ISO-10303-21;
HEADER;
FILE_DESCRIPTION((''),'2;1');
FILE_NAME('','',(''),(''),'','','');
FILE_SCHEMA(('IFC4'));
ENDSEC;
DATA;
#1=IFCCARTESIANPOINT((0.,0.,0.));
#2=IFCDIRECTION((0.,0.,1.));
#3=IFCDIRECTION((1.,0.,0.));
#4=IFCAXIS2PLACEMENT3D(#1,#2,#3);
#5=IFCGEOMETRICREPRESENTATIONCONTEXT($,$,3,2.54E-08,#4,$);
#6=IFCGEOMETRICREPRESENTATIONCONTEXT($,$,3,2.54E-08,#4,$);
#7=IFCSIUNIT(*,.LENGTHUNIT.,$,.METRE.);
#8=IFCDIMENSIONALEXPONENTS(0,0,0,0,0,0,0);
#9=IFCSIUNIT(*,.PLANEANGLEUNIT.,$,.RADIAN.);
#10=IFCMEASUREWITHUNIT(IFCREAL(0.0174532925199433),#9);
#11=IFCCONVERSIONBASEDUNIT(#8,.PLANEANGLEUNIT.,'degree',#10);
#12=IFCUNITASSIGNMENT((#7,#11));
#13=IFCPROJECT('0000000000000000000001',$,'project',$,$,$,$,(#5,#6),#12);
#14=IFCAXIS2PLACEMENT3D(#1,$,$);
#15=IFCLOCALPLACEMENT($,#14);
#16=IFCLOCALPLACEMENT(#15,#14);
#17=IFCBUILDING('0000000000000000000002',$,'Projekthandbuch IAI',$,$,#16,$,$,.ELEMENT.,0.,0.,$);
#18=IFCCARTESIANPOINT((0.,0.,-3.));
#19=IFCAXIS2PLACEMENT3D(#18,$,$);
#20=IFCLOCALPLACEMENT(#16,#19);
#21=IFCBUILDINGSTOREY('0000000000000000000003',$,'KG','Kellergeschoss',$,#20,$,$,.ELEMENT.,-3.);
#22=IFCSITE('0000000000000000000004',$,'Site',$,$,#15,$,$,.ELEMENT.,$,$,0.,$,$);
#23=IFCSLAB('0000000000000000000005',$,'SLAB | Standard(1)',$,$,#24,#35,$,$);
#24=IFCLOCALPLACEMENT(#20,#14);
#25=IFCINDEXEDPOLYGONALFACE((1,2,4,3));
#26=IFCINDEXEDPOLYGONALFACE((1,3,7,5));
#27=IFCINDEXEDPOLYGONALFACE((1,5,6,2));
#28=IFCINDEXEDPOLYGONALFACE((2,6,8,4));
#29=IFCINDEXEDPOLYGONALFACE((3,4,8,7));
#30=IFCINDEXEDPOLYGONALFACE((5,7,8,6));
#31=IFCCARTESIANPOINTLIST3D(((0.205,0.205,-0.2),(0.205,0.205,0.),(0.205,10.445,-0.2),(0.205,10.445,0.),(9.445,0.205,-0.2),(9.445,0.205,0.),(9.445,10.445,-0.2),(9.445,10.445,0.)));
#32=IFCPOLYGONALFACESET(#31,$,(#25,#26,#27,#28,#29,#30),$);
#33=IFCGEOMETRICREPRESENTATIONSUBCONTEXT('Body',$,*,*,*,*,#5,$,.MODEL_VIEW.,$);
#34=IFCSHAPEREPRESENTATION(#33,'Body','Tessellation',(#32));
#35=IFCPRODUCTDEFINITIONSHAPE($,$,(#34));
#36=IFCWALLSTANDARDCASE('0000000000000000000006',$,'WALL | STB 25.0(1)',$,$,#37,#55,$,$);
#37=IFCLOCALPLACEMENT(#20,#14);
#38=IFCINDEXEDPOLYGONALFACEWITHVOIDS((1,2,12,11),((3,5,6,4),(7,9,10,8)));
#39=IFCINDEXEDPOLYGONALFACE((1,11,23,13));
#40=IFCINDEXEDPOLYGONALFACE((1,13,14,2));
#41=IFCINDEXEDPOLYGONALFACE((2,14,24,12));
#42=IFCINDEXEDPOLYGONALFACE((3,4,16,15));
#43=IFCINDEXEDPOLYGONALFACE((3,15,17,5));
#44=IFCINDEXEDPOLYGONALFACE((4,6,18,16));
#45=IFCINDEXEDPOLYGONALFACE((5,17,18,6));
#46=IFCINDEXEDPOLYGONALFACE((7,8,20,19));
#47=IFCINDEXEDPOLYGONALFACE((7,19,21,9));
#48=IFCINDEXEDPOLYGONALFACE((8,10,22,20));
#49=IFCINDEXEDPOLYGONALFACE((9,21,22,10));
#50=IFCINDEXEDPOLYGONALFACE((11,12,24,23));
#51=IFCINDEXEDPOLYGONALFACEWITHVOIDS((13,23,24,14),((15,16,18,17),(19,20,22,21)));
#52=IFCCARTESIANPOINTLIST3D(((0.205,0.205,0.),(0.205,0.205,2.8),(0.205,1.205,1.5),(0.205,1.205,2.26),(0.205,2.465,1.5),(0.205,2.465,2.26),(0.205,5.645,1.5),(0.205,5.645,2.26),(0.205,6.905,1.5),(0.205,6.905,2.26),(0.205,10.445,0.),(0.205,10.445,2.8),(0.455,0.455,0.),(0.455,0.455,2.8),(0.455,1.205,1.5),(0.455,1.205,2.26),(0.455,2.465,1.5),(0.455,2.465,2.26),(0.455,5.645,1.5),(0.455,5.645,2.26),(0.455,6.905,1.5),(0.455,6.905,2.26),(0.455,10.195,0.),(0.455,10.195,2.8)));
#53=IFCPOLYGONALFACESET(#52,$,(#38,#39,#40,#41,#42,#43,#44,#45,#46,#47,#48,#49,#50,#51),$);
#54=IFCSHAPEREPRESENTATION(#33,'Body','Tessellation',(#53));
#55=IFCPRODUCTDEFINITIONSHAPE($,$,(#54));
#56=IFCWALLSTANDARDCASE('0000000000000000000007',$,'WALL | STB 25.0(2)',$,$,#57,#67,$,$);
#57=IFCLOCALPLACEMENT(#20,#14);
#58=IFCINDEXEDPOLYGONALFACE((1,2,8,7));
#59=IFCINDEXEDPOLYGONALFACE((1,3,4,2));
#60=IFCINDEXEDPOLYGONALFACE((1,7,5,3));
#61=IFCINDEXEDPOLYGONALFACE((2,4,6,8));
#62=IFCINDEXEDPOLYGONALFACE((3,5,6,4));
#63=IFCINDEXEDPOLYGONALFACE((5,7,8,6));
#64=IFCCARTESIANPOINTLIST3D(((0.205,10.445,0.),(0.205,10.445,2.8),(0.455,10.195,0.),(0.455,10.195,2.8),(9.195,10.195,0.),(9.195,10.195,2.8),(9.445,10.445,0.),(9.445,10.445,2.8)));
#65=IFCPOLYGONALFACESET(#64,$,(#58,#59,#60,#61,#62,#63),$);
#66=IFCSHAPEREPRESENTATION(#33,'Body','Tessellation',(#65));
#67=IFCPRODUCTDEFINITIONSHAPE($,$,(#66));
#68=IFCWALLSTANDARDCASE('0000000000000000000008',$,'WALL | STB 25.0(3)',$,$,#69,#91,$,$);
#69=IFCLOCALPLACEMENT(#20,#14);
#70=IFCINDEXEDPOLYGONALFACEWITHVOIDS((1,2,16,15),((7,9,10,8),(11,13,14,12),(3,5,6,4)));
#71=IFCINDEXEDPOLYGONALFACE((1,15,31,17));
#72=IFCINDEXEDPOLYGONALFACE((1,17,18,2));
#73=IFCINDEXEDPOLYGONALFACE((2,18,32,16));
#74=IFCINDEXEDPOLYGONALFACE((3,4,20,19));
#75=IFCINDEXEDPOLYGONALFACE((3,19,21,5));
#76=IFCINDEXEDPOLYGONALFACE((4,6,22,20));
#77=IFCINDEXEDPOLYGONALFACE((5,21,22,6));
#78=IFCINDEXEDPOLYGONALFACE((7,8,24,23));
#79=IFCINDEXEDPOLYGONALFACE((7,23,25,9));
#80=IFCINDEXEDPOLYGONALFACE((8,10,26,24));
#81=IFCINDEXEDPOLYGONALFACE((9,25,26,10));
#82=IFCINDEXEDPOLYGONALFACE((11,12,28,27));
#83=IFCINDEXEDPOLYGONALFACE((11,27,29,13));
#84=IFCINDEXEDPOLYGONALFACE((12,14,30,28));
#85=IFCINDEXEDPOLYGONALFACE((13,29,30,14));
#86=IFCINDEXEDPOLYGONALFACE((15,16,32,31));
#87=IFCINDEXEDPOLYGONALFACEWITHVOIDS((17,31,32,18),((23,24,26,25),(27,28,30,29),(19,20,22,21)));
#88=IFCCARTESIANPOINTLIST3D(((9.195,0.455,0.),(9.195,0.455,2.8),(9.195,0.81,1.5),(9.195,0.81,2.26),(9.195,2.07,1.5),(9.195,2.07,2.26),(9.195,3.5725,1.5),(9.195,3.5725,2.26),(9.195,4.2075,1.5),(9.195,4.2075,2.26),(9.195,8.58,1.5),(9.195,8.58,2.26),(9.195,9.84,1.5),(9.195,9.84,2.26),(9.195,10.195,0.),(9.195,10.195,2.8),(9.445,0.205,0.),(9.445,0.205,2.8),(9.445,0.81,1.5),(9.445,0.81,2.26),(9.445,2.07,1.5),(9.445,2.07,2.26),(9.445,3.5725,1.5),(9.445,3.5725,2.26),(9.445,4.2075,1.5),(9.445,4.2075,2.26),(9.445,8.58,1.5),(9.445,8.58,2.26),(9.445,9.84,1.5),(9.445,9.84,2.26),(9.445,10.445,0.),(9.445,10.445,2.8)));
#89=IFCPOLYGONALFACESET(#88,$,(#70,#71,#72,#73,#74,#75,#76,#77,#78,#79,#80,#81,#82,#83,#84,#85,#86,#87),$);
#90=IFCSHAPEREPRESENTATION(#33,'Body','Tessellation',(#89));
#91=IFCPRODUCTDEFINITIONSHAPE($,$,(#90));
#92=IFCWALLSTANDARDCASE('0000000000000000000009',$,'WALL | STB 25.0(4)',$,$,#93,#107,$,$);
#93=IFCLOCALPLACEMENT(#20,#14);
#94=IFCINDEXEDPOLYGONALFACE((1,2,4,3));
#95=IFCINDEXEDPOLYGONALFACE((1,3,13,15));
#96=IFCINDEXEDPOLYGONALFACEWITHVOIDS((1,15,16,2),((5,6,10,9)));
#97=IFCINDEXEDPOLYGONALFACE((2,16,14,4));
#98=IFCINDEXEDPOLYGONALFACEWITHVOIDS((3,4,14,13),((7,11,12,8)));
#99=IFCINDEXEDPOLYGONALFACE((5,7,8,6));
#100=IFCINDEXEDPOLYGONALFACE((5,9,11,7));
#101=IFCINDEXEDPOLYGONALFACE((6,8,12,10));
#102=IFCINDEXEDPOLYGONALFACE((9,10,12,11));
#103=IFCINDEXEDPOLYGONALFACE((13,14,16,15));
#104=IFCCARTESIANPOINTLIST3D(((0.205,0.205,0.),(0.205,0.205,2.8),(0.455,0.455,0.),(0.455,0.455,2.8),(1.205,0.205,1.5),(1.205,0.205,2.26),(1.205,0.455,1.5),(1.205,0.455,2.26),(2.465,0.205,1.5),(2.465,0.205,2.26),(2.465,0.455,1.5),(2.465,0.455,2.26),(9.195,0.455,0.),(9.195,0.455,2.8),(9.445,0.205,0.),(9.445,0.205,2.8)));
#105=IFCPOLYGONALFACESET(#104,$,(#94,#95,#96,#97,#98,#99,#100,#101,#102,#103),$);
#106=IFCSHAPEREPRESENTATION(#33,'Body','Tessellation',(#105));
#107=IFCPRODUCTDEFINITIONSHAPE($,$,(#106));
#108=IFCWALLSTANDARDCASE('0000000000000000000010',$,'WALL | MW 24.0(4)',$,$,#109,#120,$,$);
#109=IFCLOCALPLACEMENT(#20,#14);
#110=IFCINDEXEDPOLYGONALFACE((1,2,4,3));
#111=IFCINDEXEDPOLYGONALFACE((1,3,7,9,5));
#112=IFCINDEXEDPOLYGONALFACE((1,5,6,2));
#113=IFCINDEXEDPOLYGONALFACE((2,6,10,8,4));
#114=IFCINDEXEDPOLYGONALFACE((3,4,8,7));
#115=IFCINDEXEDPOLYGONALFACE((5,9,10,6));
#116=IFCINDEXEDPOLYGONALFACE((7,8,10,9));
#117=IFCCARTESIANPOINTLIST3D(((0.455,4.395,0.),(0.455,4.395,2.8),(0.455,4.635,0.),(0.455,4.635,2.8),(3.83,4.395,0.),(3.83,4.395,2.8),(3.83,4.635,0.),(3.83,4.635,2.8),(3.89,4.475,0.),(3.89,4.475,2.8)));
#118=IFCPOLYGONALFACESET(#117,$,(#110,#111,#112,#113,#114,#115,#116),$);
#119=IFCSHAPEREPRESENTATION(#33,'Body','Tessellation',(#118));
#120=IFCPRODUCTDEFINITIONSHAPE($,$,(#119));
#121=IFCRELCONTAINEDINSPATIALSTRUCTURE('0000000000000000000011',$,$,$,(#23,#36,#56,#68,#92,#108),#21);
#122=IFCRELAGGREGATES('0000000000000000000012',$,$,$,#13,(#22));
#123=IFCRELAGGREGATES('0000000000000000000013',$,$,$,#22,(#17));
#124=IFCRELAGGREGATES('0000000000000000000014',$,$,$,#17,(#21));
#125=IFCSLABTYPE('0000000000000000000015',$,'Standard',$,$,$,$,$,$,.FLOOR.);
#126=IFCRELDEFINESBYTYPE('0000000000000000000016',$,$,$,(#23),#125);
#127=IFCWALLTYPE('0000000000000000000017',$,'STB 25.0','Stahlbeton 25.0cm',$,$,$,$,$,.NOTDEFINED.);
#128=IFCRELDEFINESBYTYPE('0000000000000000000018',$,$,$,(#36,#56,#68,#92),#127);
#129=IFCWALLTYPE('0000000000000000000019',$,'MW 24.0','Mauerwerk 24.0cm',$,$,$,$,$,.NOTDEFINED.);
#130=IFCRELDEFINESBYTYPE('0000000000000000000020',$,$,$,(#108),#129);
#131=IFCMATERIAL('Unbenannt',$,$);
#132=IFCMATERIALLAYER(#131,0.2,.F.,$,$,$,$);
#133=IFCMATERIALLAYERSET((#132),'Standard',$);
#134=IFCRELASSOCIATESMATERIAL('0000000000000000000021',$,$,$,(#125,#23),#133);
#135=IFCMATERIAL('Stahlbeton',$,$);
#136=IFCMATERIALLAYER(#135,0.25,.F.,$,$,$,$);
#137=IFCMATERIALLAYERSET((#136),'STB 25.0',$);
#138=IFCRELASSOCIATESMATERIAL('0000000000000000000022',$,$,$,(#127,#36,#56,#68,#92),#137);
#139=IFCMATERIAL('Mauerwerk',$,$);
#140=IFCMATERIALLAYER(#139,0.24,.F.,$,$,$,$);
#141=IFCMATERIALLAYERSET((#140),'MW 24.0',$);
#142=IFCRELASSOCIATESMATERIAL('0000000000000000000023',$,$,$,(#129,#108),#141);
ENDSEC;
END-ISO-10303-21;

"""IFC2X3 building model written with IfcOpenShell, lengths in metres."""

from ifc_helpers import new_model, entity, si_unit, converted_unit, frame, frame_2d, origin, origin_with_axes, origin_2d_with_axis, place, context, subcontext, project, spatial, polyline, segment, composite_curve, rectangle, outline, extrude, material, layer, layer_set, layer_usage, type_object, element, save


model = new_model("IFC2X3")

# Units and contexts
context_of_model_1 = context(None, 3, precision=2.54e-08, world=origin_with_axes())
context_of_model_2 = context(None, 3, precision=2.54e-08, world=origin_with_axes())
body_context = subcontext(context_of_model_1, "Body", None, "MODEL_VIEW")
ifc_project = project(units=[si_unit("LENGTHUNIT", "METRE"), converted_unit("PLANEANGLEUNIT", "degree", entity("IfcReal", 0.0174532925199433), si_unit("PLANEANGLEUNIT", "RADIAN"), dimensions=[0, 0, 0, 0, 0, 0, 0])], contexts=[context_of_model_1, context_of_model_2])

# Site, building, storey
site_placement = place(None, origin())
site = spatial("IfcSite", under=ifc_project, at=site_placement, Name="Site", CompositionType="ELEMENT", RefElevation=0.0)
building_placement = place(site_placement, origin())
building = spatial("IfcBuilding", under=site, at=building_placement, Name="Projekthandbuch IAI", CompositionType="ELEMENT", ElevationOfRefHeight=0.0, ElevationOfTerrain=0.0)
storey_placement = place(building_placement, frame((0.0, 0.0, -3.0)))
storey = spatial("IfcBuildingStorey", under=building, at=storey_placement, Name="KG", Description="Kellergeschoss", CompositionType="ELEMENT", Elevation=-3.0)

# Slab
ifc_material_1 = material(Name="Unbenannt")
ifc_layer_1 = layer(ifc_material_1, 0.2, ventilated=False)
ifc_layer_set_1 = layer_set([ifc_layer_1], Name="Standard")
ifc_layer_usage_1 = layer_usage(ifc_layer_set_1, "AXIS3", "POSITIVE", 0.0)
slab_type = type_object("IfcSlabType", Name="Standard", PredefinedType="FLOOR", material=ifc_layer_set_1)
slab_placement = place(storey_placement, frame((0.205, 10.445, -0.2), z_axis=(0.0, 0.0, 1.0), x_axis=(0.0, -1.0, 0.0)))
element("IfcSlab", 1, at=slab_placement, inside=storey, type_object=slab_type, material=ifc_layer_usage_1, Name="SLAB | Standard(1)", context=body_context, shape_type="SweptSolid", held_by="IfcProductRepresentation", body=[
    extrude(rectangle(XDim=10.24, YDim=9.24, at=frame_2d((5.12, 4.62), x_axis=(1.0, 0.0))), origin(), (0.0, 0.0, 1.0), 0.2),
])

# Wall, openings
ifc_material_2 = material(Name="Stahlbeton")
ifc_layer_2 = layer(ifc_material_2, 0.25, ventilated=False)
ifc_layer_set_2 = layer_set([ifc_layer_2], Name="STB 25.0")
ifc_layer_usage_2 = layer_usage(ifc_layer_set_2, "AXIS2", "POSITIVE", -0.25)
wall_type_1 = type_object("IfcWallType", Name="STB 25.0", Description="Stahlbeton 25.0cm", PredefinedType="NOTDEFINED", material=ifc_layer_set_2)
wall_1_placement = place(storey_placement, frame((0.205, 0.205, 0.0), z_axis=(0.0, 0.0, 1.0), x_axis=(0.0, 1.0, 0.0)))
wall_1 = element("IfcWallStandardCase", 2, at=wall_1_placement, inside=storey, type_object=wall_type_1, material=ifc_layer_usage_2, Name="WALL | STB 25.0(1)", context=body_context, shape_type="SweptSolid", held_by="IfcProductRepresentation", body=[
    extrude(outline(composite_curve([segment(polyline([(0.0, 0.0), (0.25, -0.25)]), True, "CONTINUOUS"), segment(polyline([(0.25, -0.25), (4.19, -0.25)]), True, "CONTINUOUS"), segment(polyline([(4.19, -0.25), (9.99, -0.25)]), True, "CONTINUOUS"), segment(polyline([(9.99, -0.25), (10.24, 0.0)]), True, "CONTINUOUS"), segment(polyline([(10.24, 0.0), (4.19, 0.0)]), True, "CONTINUOUS"), segment(polyline([(4.19, 0.0), (0.0, 0.0)]), True, "CONTINUOUS")], self_intersect=False)), origin(), (0.0, 0.0, 1.0), 2.8),
])
opening_1_placement = place(wall_1_placement, frame((1.0, -0.125, 1.5)))
element("IfcOpeningElement", 3, at=opening_1_placement, cuts=wall_1, context=body_context, shape_type="SweptSolid", held_by="IfcProductRepresentation", body=[
    extrude(rectangle(XDim=1.26, YDim=0.76, at=origin_2d_with_axis()), frame((0.63, 0.125, 0.38), z_axis=(0.0, -1.0, 0.0), x_axis=(1.0, 0.0, 0.0)), (0.0, 0.0, 1.0), 0.25),
])
opening_2_placement = place(wall_1_placement, frame((5.44, -0.125, 1.5)))
element("IfcOpeningElement", 4, at=opening_2_placement, cuts=wall_1, context=body_context, shape_type="SweptSolid", held_by="IfcProductRepresentation", body=[
    extrude(rectangle(XDim=1.26, YDim=0.76, at=origin_2d_with_axis()), frame((0.63, 0.125, 0.38), z_axis=(0.0, -1.0, 0.0), x_axis=(1.0, 0.0, 0.0)), (0.0, 0.0, 1.0), 0.25),
])

# Wall
ifc_layer_usage_3 = layer_usage(ifc_layer_set_2, "AXIS2", "POSITIVE", -0.25)
wall_2_placement = place(storey_placement, frame((0.205, 10.445, 0.0)))
element("IfcWallStandardCase", 5, at=wall_2_placement, inside=storey, type_object=wall_type_1, material=ifc_layer_usage_3, Name="WALL | STB 25.0(2)", context=body_context, shape_type="SweptSolid", held_by="IfcProductRepresentation", body=[
    extrude(outline(composite_curve([segment(polyline([(0.0, 0.0), (0.25, -0.25)]), True, "CONTINUOUS"), segment(polyline([(0.25, -0.25), (8.99, -0.25)]), True, "CONTINUOUS"), segment(polyline([(8.99, -0.25), (9.24, 0.0)]), True, "CONTINUOUS"), segment(polyline([(9.24, 0.0), (0.0, 0.0)]), True, "CONTINUOUS")], self_intersect=False)), origin(), (0.0, 0.0, 1.0), 2.8),
])

# Wall, openings
ifc_layer_usage_4 = layer_usage(ifc_layer_set_2, "AXIS2", "POSITIVE", -0.25)
wall_3_placement = place(storey_placement, frame((9.445, 10.445, 0.0), z_axis=(0.0, 0.0, 1.0), x_axis=(0.0, -1.0, 0.0)))
wall_3 = element("IfcWallStandardCase", 6, at=wall_3_placement, inside=storey, type_object=wall_type_1, material=ifc_layer_usage_4, Name="WALL | STB 25.0(3)", context=body_context, shape_type="SweptSolid", held_by="IfcProductRepresentation", body=[
    extrude(outline(composite_curve([segment(polyline([(0.0, 0.0), (0.25, -0.25)]), True, "CONTINUOUS"), segment(polyline([(0.25, -0.25), (4.25, -0.25)]), True, "CONTINUOUS"), segment(polyline([(4.25, -0.25), (6.05, -0.25)]), True, "CONTINUOUS"), segment(polyline([(6.05, -0.25), (7.06, -0.25)]), True, "CONTINUOUS"), segment(polyline([(7.06, -0.25), (9.99, -0.25)]), True, "CONTINUOUS"), segment(polyline([(9.99, -0.25), (10.24, 0.0)]), True, "CONTINUOUS"), segment(polyline([(10.24, 0.0), (7.06, 0.0)]), True, "CONTINUOUS"), segment(polyline([(7.06, 0.0), (6.05, 0.0)]), True, "CONTINUOUS"), segment(polyline([(6.05, 0.0), (4.25, 0.0)]), True, "CONTINUOUS"), segment(polyline([(4.25, 0.0), (0.0, 0.0)]), True, "CONTINUOUS")], self_intersect=False)), origin(), (0.0, 0.0, 1.0), 2.8),
])
opening_3_placement = place(wall_3_placement, frame((0.605, -0.125, 1.5)))
element("IfcOpeningElement", 7, at=opening_3_placement, cuts=wall_3, context=body_context, shape_type="SweptSolid", held_by="IfcProductRepresentation", body=[
    extrude(rectangle(XDim=1.26, YDim=0.76, at=origin_2d_with_axis()), frame((0.63, 0.125, 0.38), z_axis=(0.0, -1.0, 0.0), x_axis=(1.0, 0.0, 0.0)), (0.0, 0.0, 1.0), 0.25),
])
opening_4_placement = place(wall_3_placement, frame((8.375, -0.125, 1.5)))
element("IfcOpeningElement", 8, at=opening_4_placement, cuts=wall_3, context=body_context, shape_type="SweptSolid", held_by="IfcProductRepresentation", body=[
    extrude(rectangle(XDim=1.26, YDim=0.76, at=origin_2d_with_axis()), frame((0.63, 0.125, 0.38), z_axis=(0.0, -1.0, 0.0), x_axis=(1.0, 0.0, 0.0)), (0.0, 0.0, 1.0), 0.25),
])
opening_5_placement = place(wall_3_placement, frame((6.2375, -0.125, 1.5)))
element("IfcOpeningElement", 9, at=opening_5_placement, cuts=wall_3, context=body_context, shape_type="SweptSolid", held_by="IfcProductRepresentation", body=[
    extrude(rectangle(XDim=0.635, YDim=0.76, at=origin_2d_with_axis()), frame((0.3175, 0.125, 0.38), z_axis=(0.0, -1.0, 0.0), x_axis=(1.0, 0.0, 0.0)), (0.0, 0.0, 1.0), 0.25),
])

# Wall, opening
ifc_layer_usage_5 = layer_usage(ifc_layer_set_2, "AXIS2", "POSITIVE", -0.25)
wall_4_placement = place(storey_placement, frame((9.445, 0.205, 0.0), z_axis=(0.0, 0.0, 1.0), x_axis=(-1.0, 0.0, 0.0)))
wall_4 = element("IfcWallStandardCase", 10, at=wall_4_placement, inside=storey, type_object=wall_type_1, material=ifc_layer_usage_5, Name="WALL | STB 25.0(4)", context=body_context, shape_type="SweptSolid", held_by="IfcProductRepresentation", body=[
    extrude(outline(composite_curve([segment(polyline([(0.0, 0.0), (0.25, -0.25)]), True, "CONTINUOUS"), segment(polyline([(0.25, -0.25), (2.625, -0.25)]), True, "CONTINUOUS"), segment(polyline([(2.625, -0.25), (5.615, -0.25)]), True, "CONTINUOUS"), segment(polyline([(5.615, -0.25), (8.99, -0.25)]), True, "CONTINUOUS"), segment(polyline([(8.99, -0.25), (9.24, 0.0)]), True, "CONTINUOUS"), segment(polyline([(9.24, 0.0), (5.615, 0.0)]), True, "CONTINUOUS"), segment(polyline([(5.615, 0.0), (2.625, 0.0)]), True, "CONTINUOUS"), segment(polyline([(2.625, 0.0), (0.0, 0.0)]), True, "CONTINUOUS")], self_intersect=False)), origin(), (0.0, 0.0, 1.0), 2.8),
])
opening_6_placement = place(wall_4_placement, frame((6.98, -0.125, 1.5)))
element("IfcOpeningElement", 11, at=opening_6_placement, cuts=wall_4, context=body_context, shape_type="SweptSolid", held_by="IfcProductRepresentation", body=[
    extrude(rectangle(XDim=1.26, YDim=0.76, at=origin_2d_with_axis()), frame((0.63, 0.125, 0.38), z_axis=(0.0, -1.0, 0.0), x_axis=(1.0, 0.0, 0.0)), (0.0, 0.0, 1.0), 0.25),
])
ifc_material_3 = material(Name="Mauerwerk")

# Shared definitions
ifc_layer_3 = layer(ifc_material_3, 0.24, ventilated=False)
ifc_layer_set_3 = layer_set([ifc_layer_3], Name="MW 24.0")
wall_type_2 = type_object("IfcWallType", Name="MW 24.0", Description="Mauerwerk 24.0cm", PredefinedType="NOTDEFINED", material=ifc_layer_set_3)

# Wall
ifc_layer_usage_6 = layer_usage(ifc_layer_set_3, "AXIS2", "POSITIVE", -0.24)
wall_5_placement = place(storey_placement, frame((3.83, 4.395, 0.0), z_axis=(0.0, 0.0, 1.0), x_axis=(-1.0, 0.0, 0.0)))
element("IfcWallStandardCase", 12, at=wall_5_placement, inside=storey, type_object=wall_type_2, material=ifc_layer_usage_6, Name="WALL | MW 24.0(4)", context=body_context, shape_type="SweptSolid", held_by="IfcProductRepresentation", body=[
    extrude(outline(composite_curve([segment(polyline([(0.0, 0.0), (-0.06, -0.08)]), True, "CONTINUOUS"), segment(polyline([(-0.06, -0.08), (0.0, -0.24)]), True, "CONTINUOUS"), segment(polyline([(0.0, -0.24), (3.375, -0.24)]), True, "CONTINUOUS"), segment(polyline([(3.375, -0.24), (3.375, 0.0)]), True, "CONTINUOUS"), segment(polyline([(3.375, 0.0), (0.0, 0.0)]), True, "CONTINUOUS")], self_intersect=False)), origin(), (0.0, 0.0, 1.0), 2.8),
])

save(model, "model.ifc")
